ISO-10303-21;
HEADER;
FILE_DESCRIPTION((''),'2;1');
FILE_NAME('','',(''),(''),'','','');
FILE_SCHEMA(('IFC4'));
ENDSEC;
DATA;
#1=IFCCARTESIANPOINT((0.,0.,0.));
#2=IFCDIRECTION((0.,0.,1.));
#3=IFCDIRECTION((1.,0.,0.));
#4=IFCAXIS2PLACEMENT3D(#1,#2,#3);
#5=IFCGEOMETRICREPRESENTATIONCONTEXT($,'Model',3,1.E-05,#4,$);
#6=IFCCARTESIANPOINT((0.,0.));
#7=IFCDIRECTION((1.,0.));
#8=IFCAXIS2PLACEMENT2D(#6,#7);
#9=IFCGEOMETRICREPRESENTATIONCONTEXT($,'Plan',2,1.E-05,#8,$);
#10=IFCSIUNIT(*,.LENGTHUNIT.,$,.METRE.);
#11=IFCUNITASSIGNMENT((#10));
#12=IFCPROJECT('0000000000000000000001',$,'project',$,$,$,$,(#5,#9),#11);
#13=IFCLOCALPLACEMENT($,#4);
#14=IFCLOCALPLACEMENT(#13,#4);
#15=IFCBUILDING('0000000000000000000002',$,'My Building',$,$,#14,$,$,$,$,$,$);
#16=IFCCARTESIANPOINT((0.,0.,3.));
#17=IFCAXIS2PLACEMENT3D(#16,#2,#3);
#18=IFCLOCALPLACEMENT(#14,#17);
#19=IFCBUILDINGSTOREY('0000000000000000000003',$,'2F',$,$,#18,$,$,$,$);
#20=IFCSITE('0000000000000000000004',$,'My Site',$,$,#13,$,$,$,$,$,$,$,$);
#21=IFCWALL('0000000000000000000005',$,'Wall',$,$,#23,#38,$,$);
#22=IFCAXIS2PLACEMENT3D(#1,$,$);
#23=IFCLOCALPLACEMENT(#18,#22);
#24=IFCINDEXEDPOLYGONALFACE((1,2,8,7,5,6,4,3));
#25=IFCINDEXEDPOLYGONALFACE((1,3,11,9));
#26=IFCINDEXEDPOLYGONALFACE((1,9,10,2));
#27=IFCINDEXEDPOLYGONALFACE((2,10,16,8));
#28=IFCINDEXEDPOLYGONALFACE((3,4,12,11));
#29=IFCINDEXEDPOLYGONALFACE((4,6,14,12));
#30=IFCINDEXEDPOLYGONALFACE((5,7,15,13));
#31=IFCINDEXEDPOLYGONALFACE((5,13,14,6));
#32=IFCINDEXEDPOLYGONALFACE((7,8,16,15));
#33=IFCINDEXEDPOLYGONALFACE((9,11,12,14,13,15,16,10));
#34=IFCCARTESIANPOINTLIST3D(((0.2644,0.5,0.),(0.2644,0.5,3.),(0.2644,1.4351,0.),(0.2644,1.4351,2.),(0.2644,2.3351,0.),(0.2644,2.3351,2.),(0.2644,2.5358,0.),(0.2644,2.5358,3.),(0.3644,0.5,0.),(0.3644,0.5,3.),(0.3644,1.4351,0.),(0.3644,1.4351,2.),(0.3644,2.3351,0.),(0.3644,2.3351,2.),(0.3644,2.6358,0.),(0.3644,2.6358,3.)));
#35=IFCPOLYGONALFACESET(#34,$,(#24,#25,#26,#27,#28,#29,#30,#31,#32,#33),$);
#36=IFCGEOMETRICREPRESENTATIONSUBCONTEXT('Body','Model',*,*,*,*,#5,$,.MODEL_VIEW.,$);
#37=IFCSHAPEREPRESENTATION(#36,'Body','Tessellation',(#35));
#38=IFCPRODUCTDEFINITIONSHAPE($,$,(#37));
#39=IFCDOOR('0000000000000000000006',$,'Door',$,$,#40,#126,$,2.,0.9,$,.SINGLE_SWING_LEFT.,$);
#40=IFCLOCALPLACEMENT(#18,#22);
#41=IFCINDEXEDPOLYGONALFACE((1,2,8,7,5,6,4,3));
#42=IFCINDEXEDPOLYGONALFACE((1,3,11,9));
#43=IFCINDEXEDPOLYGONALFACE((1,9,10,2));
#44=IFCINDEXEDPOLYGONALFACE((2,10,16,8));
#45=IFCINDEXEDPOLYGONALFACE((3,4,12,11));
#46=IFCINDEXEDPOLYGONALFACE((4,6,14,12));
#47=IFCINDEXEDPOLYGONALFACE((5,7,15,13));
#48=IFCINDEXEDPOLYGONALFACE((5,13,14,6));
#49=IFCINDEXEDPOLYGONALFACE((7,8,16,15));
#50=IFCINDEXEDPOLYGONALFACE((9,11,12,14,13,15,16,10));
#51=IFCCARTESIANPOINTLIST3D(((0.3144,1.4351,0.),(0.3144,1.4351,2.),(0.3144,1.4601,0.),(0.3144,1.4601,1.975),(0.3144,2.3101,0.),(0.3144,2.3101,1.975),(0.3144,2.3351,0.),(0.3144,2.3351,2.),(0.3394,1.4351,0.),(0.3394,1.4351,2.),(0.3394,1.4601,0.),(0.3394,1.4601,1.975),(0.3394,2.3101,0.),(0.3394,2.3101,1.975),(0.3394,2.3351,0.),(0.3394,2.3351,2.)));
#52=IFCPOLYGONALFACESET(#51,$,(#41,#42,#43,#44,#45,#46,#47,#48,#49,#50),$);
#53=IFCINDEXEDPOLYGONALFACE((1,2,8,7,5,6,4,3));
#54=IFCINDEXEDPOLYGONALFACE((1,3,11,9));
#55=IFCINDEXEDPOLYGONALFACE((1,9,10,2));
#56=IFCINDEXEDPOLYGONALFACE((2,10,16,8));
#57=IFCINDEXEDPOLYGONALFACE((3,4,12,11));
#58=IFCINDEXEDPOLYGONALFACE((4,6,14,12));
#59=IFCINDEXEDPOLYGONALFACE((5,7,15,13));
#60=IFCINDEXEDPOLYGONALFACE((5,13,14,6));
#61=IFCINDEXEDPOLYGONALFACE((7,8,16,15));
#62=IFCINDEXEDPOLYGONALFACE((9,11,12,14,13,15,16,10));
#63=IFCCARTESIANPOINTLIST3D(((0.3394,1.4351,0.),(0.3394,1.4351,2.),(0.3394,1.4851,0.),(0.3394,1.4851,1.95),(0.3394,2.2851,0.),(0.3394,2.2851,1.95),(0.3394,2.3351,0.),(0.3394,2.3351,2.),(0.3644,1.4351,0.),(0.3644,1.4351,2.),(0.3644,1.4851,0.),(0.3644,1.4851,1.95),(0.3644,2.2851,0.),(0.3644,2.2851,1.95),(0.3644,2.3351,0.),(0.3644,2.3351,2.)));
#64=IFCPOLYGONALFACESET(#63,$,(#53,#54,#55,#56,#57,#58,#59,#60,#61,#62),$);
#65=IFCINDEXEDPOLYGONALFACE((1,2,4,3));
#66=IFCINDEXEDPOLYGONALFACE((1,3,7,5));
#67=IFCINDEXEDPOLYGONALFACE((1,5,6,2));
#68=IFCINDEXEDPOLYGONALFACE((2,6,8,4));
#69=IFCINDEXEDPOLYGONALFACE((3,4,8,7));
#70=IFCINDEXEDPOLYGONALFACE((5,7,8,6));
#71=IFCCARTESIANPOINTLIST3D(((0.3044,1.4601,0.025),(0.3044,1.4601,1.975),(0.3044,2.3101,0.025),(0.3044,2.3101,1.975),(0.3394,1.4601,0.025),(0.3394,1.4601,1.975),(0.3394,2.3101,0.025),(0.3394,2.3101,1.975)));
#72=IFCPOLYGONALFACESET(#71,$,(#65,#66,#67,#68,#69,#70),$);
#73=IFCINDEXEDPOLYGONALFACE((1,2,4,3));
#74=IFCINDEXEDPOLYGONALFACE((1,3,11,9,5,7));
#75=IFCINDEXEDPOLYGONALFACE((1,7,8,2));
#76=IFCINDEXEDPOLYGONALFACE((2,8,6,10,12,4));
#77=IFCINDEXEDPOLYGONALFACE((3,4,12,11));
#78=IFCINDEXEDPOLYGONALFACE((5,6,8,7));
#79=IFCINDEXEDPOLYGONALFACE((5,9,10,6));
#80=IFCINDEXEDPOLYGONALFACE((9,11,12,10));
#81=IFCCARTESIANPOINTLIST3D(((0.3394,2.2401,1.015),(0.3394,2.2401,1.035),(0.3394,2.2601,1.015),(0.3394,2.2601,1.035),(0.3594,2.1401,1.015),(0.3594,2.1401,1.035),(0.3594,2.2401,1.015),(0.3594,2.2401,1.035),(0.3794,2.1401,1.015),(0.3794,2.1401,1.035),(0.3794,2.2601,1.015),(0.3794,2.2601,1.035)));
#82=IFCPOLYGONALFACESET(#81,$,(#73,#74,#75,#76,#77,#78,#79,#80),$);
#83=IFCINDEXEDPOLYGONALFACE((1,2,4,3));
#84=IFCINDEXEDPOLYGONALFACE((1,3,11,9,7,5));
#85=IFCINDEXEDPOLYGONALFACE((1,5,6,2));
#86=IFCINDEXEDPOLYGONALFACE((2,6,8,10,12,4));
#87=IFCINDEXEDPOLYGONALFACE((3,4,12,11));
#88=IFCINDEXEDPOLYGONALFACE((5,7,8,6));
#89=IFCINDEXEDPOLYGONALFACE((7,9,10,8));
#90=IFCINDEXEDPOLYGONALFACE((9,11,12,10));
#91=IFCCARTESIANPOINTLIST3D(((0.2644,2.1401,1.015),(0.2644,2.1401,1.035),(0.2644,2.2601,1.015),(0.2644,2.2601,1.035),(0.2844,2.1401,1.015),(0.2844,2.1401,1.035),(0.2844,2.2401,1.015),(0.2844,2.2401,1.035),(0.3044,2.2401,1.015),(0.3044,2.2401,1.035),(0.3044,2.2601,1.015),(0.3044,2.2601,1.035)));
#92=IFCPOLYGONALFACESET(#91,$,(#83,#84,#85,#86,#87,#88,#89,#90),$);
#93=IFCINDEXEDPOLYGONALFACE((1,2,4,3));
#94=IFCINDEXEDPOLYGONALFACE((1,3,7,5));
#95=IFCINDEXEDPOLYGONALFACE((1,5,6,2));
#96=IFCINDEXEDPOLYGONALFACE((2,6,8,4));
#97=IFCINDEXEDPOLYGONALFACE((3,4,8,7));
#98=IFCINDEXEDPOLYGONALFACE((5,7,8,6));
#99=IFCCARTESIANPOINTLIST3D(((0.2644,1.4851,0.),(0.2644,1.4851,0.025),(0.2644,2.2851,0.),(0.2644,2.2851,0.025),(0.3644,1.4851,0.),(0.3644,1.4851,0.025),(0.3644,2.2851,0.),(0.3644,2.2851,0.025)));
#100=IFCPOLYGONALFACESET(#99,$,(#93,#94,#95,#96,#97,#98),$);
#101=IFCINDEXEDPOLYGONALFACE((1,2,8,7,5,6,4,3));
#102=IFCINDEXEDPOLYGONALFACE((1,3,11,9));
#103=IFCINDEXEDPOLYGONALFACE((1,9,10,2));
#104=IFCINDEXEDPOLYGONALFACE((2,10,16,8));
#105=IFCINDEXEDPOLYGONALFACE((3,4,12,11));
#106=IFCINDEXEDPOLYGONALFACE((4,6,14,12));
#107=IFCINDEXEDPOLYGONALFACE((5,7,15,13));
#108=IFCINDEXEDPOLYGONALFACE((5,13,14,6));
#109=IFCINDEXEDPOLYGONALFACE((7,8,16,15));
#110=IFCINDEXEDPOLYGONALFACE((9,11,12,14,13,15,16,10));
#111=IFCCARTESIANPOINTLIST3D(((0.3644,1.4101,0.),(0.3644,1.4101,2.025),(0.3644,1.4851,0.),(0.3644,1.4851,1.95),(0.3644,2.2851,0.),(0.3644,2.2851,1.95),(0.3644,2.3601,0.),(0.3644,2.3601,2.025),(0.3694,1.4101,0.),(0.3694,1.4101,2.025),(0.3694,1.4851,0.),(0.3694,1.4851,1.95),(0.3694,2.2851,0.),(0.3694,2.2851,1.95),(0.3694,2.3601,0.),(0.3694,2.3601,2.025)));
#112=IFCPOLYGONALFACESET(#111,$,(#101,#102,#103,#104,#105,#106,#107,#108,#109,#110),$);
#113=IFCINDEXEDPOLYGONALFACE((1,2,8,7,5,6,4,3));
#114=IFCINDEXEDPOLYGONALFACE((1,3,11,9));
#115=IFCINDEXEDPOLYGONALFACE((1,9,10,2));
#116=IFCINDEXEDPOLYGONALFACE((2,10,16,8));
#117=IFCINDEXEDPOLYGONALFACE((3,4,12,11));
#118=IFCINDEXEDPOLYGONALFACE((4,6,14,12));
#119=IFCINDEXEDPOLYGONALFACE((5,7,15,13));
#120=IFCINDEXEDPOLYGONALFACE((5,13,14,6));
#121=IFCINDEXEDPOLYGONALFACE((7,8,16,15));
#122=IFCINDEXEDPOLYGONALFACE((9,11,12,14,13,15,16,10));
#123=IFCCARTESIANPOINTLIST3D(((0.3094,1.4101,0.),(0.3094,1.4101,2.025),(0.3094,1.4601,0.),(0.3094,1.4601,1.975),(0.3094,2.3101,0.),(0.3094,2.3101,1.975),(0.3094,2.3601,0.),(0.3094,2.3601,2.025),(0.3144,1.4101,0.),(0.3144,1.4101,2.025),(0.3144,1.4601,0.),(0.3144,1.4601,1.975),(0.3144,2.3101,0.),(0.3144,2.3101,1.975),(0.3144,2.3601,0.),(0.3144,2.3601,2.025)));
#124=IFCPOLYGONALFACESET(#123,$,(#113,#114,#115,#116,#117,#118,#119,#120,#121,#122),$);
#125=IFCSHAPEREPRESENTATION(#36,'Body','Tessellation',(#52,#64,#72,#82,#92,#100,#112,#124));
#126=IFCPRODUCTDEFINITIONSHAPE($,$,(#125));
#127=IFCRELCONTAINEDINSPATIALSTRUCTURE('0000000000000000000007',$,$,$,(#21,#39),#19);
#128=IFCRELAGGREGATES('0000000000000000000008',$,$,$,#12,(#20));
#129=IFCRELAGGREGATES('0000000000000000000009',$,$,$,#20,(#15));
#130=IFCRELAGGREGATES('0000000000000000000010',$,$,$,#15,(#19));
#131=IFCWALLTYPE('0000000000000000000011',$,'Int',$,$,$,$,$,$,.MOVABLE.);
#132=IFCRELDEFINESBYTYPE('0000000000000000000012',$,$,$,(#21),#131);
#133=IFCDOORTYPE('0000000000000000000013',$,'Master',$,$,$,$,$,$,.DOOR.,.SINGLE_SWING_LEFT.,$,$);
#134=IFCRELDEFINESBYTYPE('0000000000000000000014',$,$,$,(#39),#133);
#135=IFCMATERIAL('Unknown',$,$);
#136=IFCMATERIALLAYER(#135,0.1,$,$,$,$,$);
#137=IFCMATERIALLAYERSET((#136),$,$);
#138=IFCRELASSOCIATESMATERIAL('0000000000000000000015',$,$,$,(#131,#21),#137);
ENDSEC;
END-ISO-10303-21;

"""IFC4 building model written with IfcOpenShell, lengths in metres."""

from ifc_helpers import new_model, entity, si_unit, frame, origin_with_axes, origin_2d_with_axis, place, context, subcontext, project, spatial, line, indexed_curve, outline, extrude, shape, source, transform, mapped, material, layer, layer_set, layer_usage, type_object, type_shapes, element, fill, save


model = new_model("IFC4")

# Units and contexts
model_context = context("Model", 3, precision=1e-05, world=origin_with_axes())
plan_context = context("Plan", 2, precision=1e-05, world=origin_2d_with_axis())
body_context_1 = subcontext(model_context, "Body", "Model", "MODEL_VIEW")
body_context_2 = subcontext(plan_context, "Body", "Plan", "PLAN_VIEW")
ifc_project = project(units=[si_unit("LENGTHUNIT", "METRE")], contexts=[model_context, plan_context])

# Site, building, storey
site_placement = place(None, origin_with_axes())
site = spatial("IfcSite", under=ifc_project, at=site_placement, Name="My Site")
building_placement = place(site_placement, origin_with_axes())
building = spatial("IfcBuilding", under=site, at=building_placement, Name="My Building")
storey_placement = place(building_placement, frame((0.0, 0.0, 3.0), z_axis=(0.0, 0.0, 1.0), x_axis=(1.0, 0.0, 0.0)))
storey = spatial("IfcBuildingStorey", under=building, at=storey_placement, Name="2F")

# Shared definitions
ifc_material = material(Name="Unknown")

# Shared definitions
ifc_layer_1 = layer(ifc_material, 0.1)
ifc_layer_set_1 = layer_set([ifc_layer_1])
wall_type_1 = type_object("IfcWallType", Name="Int", PredefinedType="MOVABLE", material=ifc_layer_set_1)

# Wall, opening, door
ifc_layer_usage_1 = layer_usage(ifc_layer_set_1, "AXIS2", "POSITIVE", 0.0)
wall_1_placement = place(storey_placement, frame((0.2644, 2.5358, 0.0), z_axis=(0.0, 0.0, 1.0), x_axis=(0.0, -1.0, 0.0)))
wall_1 = element("IfcWall", 1, at=wall_1_placement, inside=storey, type_object=wall_type_1, material=ifc_layer_usage_1, Name="Wall", context=body_context_1, shape_type="SweptSolid", body=[
    extrude(outline(indexed_curve([(0.0, 0.0), (-0.1, 0.1), (2.0358, 0.1), (2.0358, 0.0)], segments=[line(1, 2, 3, 4, 1)])), origin_with_axes(), (0.0, 0.0, 1.0), 3.0),
])
shared_shape_1 = source(origin_with_axes(), body_context_1, "Body", "SweptSolid", [
    extrude(outline(indexed_curve([(0.0, 0.0), (0.9, 0.0), (0.9, 2.0), (0.0, 2.0)], segments=[line(1, 2, 3, 4, 1)])), frame((0.0, -0.6, 0.0), z_axis=(0.0, -1.0, 0.0), x_axis=(1.0, 0.0, 0.0)), (0.0, 0.0, -1.0), 1.2),
])
opening_1_placement = place(wall_1_placement, frame((1.1007, 0.1, 0.0), z_axis=(0.0, 0.0, 1.0), x_axis=(-1.0, 0.0, 0.0)))
opening_1 = element("IfcOpeningElement", 2, at=opening_1_placement, cuts=wall_1, PredefinedType="OPENING", context=body_context_1, shape_type="MappedRepresentation", body=[
    mapped(shared_shape_1, transform((0.0, 0.0, 0.0), x_axis=(1.0, 0.0, 0.0), y_axis=(0.0, 1.0, 0.0), z_axis=(0.0, 0.0, 1.0), scale=1.0)),
])
door_type_1 = type_object("IfcDoorType", Name="Master", OperationType="SINGLE_SWING_LEFT", PredefinedType="DOOR")
shared_shape_2 = source(origin_with_axes(), body_context_1, "Body", "SweptSolid", [
    extrude(outline(indexed_curve([(0.0, 0.0), (0.0, 2.0), (0.9, 2.0), (0.9, 0.0), (0.875, 0.0), (0.875, 1.975), (0.025, 1.975), (0.025, 0.0)], segments=[line(1, 2, 3, 4, 5, 6, 7, 8, 1)])), frame((0.0, 0.025, 0.0), z_axis=(0.0, -1.0, 0.0), x_axis=(1.0, 0.0, 0.0)), (0.0, 0.0, -1.0), 0.025),
    extrude(outline(indexed_curve([(0.0, 0.0), (0.0, 2.0), (0.9, 2.0), (0.9, 0.0), (0.85, 0.0), (0.85, 1.95), (0.05, 1.95), (0.05, 0.0)], segments=[line(1, 2, 3, 4, 5, 6, 7, 8, 1)])), frame((0.0, 0.0, 0.0), z_axis=(0.0, -1.0, 0.0), x_axis=(1.0, 0.0, 0.0)), (0.0, 0.0, -1.0), 0.025),
    extrude(outline(indexed_curve([(0.0, 0.0), (0.85, 0.0), (0.85, 0.035), (0.0, 0.035)], segments=[line(1, 2, 3, 4, 1)])), frame((0.025, 0.025, 0.025), z_axis=(0.0, 0.0, 1.0), x_axis=(1.0, 0.0, 0.0)), (0.0, 0.0, 1.0), 1.95),
    extrude(outline(indexed_curve([(0.0, 0.0), (0.0, -0.04), (-0.12, -0.04), (-0.12, -0.02), (-0.02, -0.02), (-0.02, 0.0)], segments=[line(1, 2, 3, 4, 5, 6, 1)])), frame((0.825, 0.025, 1.015), z_axis=(0.0, 0.0, 1.0), x_axis=(1.0, 0.0, 0.0)), (0.0, 0.0, 1.0), 0.02),
    extrude(outline(indexed_curve([(0.0, 0.0), (0.0, 0.04), (-0.12, 0.04), (-0.12, 0.02), (-0.02, 0.02), (-0.02, 0.0)], segments=[line(1, 2, 3, 4, 5, 6, 1)])), frame((0.825, 0.06, 1.015), z_axis=(0.0, 0.0, 1.0), x_axis=(1.0, 0.0, 0.0)), (0.0, 0.0, 1.0), 0.02),
    extrude(outline(indexed_curve([(0.0, 0.0), (0.8, 0.0), (0.8, 0.1), (0.0, 0.1)], segments=[line(1, 2, 3, 4, 1)])), frame((0.05, 0.0, 0.0), z_axis=(0.0, 0.0, 1.0), x_axis=(1.0, 0.0, 0.0)), (0.0, 0.0, 1.0), 0.025),
    extrude(outline(indexed_curve([(0.0, 0.0), (0.0, 2.025), (0.95, 2.025), (0.95, 0.0), (0.875, 0.0), (0.875, 1.95), (0.075, 1.95), (0.075, 0.0)], segments=[line(1, 2, 3, 4, 5, 6, 7, 8, 1)])), frame((-0.025, -0.005, 0.0), z_axis=(0.0, -1.0, 0.0), x_axis=(1.0, 0.0, 0.0)), (0.0, 0.0, -1.0), 0.005),
    extrude(outline(indexed_curve([(0.0, 0.0), (0.0, 2.025), (0.95, 2.025), (0.95, 0.0), (0.9, 0.0), (0.9, 1.975), (0.05, 1.975), (0.05, 0.0)], segments=[line(1, 2, 3, 4, 5, 6, 7, 8, 1)])), frame((-0.025, 0.05, 0.0), z_axis=(0.0, -1.0, 0.0), x_axis=(1.0, 0.0, 0.0)), (0.0, 0.0, -1.0), 0.005),
])
shared_shape_3 = source(origin_with_axes(), body_context_2, "Body", "Curve2D", [
    entity("IfcIndexedPolyCurve", entity("IfcCartesianPointList2D", [[0.0, 0.0], [0.0, 0.05], [0.025, 0.05], [0.025, 0.025], [0.05, 0.025], [0.05, 0.0]]), [entity("IfcLineIndex", [1, 2, 3, 4, 5, 6, 1])]),
    entity("IfcIndexedPolyCurve", entity("IfcCartesianPointList2D", [[0.9, 0.0], [0.9, 0.05], [0.875, 0.05], [0.875, 0.025], [0.85, 0.025], [0.85, 0.0]]), [entity("IfcLineIndex", [1, 2, 3, 4, 5, 6, 1])]),
    entity("IfcTrimmedCurve", entity("IfcEllipse", entity("IfcAxis2Placement2D", entity("IfcCartesianPoint", [0.06, 0.05]), entity("IfcDirection", [1.0, 0.0])), 0.815, 0.85), [entity("IfcCartesianPoint", [0.875, 0.05])], [entity("IfcCartesianPoint", [0.06, 0.9])], True, "CARTESIAN"),
    entity("IfcIndexedPolyCurve", entity("IfcCartesianPointList2D", [[0.025, 0.05], [0.06, 0.05], [0.06, 0.9], [0.025, 0.9]]), [entity("IfcLineIndex", [1, 2, 3, 4, 1])]),
])
type_shapes(door_type_1, [shared_shape_2, shared_shape_3])
door_1_placement = place(opening_1_placement, frame((0.0, 0.0, 0.0), z_axis=(0.0, 0.0, 1.0), x_axis=(1.0, 0.0, 0.0)))
door_1 = element("IfcDoor", 3, at=door_1_placement, inside=storey, type_object=door_type_1, Name="Door", OperationType="SINGLE_SWING_LEFT", OverallHeight=2.0, OverallWidth=0.9, shapes=[
    shape(body_context_1, "Body", "MappedRepresentation", [mapped(shared_shape_2, transform((0.0, 0.0, 0.0), x_axis=(1.0, 0.0, 0.0), y_axis=(0.0, 1.0, 0.0), z_axis=(0.0, 0.0, 1.0), scale=1.0))]),
    shape(body_context_2, "Body", "MappedRepresentation", [mapped(shared_shape_3, transform((0.0, 0.0, 0.0), x_axis=(1.0, 0.0, 0.0), y_axis=(0.0, 1.0, 0.0), z_axis=(0.0, 0.0, 1.0), scale=1.0))]),
])
fill(opening_1, door_1)

save(model, "model.ifc")
